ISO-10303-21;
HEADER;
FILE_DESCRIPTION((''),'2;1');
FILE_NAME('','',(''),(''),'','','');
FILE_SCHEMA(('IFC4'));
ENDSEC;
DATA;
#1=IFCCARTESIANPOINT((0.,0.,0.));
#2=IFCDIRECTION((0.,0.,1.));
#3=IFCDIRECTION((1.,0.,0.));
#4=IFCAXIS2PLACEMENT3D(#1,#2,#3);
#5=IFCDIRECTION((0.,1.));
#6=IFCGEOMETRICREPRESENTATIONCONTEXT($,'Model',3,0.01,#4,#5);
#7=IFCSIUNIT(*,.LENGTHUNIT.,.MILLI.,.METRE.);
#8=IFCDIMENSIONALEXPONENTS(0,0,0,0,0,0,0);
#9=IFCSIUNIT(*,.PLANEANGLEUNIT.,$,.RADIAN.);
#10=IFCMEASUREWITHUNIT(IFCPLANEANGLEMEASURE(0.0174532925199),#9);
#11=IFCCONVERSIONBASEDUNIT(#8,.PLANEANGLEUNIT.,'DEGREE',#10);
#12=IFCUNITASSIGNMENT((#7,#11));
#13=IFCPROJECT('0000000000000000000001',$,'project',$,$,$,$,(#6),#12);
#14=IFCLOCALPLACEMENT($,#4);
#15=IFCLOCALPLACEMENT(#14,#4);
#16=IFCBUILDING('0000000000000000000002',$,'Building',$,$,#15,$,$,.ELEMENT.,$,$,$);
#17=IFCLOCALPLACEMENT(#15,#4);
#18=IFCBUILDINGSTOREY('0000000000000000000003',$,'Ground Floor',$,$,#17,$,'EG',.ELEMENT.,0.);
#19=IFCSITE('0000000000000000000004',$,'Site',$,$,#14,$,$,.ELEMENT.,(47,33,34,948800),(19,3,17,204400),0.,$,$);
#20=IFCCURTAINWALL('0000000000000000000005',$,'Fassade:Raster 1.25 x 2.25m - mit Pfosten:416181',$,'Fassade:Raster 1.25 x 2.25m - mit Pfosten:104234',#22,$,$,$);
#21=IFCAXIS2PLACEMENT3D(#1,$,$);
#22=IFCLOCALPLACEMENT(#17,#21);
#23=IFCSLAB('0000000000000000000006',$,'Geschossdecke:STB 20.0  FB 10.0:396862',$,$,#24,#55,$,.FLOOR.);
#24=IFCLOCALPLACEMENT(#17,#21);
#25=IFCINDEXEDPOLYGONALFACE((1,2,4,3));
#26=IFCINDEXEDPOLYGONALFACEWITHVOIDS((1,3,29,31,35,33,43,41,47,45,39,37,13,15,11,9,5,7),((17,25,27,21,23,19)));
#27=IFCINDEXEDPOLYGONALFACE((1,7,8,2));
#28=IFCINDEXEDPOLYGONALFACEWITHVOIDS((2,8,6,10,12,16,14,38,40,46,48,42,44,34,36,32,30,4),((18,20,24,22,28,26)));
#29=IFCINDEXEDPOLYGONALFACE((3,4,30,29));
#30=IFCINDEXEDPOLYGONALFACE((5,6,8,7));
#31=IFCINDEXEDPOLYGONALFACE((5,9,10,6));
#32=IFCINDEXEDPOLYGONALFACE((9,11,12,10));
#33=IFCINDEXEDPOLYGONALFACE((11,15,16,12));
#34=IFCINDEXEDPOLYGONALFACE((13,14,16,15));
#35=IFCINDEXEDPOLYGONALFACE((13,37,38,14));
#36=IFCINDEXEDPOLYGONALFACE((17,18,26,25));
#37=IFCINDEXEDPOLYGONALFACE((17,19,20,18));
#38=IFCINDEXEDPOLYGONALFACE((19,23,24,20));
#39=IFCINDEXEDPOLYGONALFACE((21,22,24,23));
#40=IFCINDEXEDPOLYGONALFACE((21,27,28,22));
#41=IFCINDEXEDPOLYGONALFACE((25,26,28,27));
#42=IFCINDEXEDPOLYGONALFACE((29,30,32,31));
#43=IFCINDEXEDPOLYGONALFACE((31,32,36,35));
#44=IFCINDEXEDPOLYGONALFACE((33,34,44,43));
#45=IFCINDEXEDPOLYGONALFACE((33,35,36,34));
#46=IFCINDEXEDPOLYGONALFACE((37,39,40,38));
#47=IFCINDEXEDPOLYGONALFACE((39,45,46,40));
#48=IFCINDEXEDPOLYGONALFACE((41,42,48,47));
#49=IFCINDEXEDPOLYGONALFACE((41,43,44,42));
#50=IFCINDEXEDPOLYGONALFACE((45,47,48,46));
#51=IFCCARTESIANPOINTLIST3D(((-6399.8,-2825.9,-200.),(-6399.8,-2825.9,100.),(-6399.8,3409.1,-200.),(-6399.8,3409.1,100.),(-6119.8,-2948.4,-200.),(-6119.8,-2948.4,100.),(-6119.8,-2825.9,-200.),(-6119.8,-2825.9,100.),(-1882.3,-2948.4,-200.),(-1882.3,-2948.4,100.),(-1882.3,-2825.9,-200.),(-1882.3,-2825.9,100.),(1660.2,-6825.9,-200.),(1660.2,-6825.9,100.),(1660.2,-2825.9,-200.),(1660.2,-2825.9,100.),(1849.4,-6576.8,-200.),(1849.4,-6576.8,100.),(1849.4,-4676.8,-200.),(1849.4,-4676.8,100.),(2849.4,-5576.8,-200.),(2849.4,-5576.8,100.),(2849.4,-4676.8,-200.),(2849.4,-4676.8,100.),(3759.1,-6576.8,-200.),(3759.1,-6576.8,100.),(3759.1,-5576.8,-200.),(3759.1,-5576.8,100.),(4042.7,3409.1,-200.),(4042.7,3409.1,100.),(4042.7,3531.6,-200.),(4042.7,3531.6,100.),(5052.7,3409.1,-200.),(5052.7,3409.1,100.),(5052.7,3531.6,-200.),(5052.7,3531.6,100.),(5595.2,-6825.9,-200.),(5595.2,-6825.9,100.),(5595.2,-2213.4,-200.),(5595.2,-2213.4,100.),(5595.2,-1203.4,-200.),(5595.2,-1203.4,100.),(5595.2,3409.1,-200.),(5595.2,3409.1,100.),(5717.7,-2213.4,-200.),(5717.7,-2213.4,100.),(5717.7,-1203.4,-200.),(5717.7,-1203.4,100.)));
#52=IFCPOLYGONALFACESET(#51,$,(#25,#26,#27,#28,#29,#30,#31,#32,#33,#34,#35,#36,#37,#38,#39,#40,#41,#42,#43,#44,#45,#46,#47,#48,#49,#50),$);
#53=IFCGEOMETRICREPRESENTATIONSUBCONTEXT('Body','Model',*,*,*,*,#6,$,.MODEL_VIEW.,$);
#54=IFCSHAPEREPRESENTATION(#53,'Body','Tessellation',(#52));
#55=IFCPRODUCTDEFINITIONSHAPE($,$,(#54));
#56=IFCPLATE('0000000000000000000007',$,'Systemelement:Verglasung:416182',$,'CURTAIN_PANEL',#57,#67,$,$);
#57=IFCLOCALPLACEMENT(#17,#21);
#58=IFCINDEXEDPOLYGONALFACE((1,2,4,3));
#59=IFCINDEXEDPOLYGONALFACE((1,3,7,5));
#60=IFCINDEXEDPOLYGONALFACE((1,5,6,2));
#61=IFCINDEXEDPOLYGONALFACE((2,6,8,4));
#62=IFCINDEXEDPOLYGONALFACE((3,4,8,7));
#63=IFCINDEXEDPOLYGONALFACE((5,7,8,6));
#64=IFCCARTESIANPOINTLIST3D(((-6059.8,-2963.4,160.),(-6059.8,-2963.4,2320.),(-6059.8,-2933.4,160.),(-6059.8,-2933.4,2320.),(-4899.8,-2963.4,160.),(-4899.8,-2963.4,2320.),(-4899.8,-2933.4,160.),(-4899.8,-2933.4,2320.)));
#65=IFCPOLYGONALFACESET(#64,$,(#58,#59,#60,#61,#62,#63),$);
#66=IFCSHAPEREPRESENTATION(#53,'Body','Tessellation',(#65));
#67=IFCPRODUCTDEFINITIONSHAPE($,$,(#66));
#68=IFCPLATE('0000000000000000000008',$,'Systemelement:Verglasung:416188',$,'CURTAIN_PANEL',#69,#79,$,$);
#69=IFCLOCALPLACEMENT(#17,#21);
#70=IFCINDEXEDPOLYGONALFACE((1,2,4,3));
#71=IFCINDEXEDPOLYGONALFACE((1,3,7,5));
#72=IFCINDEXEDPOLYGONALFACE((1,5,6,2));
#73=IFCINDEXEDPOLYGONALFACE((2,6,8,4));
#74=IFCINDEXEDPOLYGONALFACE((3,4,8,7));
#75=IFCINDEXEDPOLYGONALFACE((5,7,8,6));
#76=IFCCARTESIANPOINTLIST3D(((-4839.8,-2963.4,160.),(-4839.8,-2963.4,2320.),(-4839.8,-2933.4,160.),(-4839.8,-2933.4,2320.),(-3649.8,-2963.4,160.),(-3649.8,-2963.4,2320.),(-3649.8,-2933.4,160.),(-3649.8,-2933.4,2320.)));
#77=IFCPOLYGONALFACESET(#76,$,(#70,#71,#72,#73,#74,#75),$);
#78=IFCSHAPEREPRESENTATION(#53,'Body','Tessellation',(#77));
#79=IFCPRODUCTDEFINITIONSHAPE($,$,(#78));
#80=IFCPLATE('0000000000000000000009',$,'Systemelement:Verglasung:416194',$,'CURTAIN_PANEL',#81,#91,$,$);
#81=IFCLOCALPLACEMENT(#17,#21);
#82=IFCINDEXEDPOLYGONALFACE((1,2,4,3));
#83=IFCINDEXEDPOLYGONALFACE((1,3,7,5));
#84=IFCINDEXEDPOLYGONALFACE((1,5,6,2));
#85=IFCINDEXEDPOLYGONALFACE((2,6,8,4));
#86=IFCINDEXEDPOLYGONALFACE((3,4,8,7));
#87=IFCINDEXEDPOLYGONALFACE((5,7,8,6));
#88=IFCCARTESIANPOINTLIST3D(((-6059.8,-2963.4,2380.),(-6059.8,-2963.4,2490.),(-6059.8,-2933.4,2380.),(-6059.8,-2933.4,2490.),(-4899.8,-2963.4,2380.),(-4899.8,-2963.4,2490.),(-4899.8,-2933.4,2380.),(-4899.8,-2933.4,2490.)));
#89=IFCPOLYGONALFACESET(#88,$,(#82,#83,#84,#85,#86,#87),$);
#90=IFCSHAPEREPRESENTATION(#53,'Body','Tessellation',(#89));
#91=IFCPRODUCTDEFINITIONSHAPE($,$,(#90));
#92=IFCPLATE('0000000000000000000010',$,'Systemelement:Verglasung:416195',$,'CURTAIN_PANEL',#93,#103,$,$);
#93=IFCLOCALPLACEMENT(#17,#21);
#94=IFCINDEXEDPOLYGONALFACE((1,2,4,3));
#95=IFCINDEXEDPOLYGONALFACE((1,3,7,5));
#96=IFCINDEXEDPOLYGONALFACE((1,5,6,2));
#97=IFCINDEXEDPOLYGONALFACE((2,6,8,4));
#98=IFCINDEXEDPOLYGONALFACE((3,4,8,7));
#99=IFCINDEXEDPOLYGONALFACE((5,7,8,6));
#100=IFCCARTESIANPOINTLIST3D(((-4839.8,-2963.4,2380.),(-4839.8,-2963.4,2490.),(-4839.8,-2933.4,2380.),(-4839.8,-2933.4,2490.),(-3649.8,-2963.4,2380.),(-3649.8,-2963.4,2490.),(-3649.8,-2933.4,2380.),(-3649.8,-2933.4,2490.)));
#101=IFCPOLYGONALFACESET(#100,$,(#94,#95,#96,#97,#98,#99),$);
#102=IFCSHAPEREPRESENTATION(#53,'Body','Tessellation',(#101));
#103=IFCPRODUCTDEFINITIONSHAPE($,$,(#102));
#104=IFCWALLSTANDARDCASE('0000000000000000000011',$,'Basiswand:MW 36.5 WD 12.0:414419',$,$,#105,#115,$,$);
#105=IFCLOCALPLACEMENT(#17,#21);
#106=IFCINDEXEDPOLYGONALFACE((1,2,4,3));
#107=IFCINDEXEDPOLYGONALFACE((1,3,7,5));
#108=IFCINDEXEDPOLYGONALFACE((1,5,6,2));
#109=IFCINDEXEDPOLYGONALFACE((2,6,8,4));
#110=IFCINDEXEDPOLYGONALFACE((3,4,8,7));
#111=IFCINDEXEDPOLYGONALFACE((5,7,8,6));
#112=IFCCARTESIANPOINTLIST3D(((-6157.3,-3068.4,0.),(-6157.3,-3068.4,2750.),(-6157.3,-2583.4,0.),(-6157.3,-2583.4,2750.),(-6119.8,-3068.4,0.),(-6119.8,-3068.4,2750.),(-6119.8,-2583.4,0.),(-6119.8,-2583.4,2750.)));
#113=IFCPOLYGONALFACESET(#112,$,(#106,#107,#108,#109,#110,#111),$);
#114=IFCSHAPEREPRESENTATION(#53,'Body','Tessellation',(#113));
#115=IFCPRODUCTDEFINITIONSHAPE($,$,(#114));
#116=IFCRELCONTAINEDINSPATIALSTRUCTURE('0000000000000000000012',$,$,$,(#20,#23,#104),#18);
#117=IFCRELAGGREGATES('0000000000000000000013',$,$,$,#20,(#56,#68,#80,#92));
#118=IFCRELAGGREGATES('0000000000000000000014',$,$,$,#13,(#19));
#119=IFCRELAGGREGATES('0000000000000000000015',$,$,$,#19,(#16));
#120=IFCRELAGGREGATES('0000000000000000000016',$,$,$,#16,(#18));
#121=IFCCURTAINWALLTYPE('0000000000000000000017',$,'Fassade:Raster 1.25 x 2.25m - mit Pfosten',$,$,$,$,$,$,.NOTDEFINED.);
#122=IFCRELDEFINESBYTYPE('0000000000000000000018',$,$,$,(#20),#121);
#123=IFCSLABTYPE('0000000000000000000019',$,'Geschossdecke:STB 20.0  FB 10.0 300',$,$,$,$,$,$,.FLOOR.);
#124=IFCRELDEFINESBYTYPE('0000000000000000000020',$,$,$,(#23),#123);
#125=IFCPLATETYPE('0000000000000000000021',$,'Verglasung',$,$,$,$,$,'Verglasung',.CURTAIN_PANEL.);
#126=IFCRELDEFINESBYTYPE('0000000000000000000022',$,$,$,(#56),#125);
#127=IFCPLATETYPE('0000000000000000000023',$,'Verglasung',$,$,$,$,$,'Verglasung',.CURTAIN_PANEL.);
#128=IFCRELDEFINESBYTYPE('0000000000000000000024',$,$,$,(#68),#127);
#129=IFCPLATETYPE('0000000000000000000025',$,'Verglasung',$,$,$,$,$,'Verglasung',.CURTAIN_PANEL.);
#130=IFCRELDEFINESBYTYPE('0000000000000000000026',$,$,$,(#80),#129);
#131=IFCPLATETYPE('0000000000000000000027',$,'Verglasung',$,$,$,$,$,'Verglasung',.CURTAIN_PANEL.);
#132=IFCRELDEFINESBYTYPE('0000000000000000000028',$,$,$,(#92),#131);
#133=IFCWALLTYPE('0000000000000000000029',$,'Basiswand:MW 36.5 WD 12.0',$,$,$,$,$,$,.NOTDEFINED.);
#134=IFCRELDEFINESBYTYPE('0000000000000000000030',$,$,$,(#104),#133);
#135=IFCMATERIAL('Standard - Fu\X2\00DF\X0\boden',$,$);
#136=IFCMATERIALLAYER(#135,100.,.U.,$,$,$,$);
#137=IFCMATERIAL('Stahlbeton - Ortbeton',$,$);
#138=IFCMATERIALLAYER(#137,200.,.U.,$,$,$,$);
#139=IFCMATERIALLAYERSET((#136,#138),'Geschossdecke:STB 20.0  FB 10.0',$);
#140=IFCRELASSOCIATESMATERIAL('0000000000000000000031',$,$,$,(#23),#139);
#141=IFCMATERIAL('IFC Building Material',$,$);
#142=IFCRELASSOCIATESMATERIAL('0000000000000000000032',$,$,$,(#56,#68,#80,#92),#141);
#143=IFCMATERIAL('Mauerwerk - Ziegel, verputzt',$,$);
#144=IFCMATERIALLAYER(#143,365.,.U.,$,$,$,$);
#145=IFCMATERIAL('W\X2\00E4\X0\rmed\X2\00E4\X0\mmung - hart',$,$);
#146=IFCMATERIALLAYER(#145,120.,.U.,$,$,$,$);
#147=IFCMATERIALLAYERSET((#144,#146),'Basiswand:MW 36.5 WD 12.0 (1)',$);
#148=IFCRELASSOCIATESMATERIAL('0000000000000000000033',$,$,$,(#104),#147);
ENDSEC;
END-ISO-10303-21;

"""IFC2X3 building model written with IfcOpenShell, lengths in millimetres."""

from ifc_helpers import new_model, entity, si_unit, converted_unit, direction, frame, origin_with_axes, origin_2d_with_axis, place, context, subcontext, project, spatial, polyline, rectangle, outline, extrude, material, layer, layer_set, layer_usage, type_object, element, aggregate, save


model = new_model("IFC2X3")

# Units and contexts
model_context = context("Model", 3, precision=0.01, world=origin_with_axes(), true_north=direction((0.0, 1.0)))
body_context = subcontext(model_context, "Body", "Model", "MODEL_VIEW")
ifc_project = project(units=[si_unit("LENGTHUNIT", "METRE", prefix="MILLI"), converted_unit("PLANEANGLEUNIT", "DEGREE", entity("IfcPlaneAngleMeasure", 0.0174532925199), si_unit("PLANEANGLEUNIT", "RADIAN"), dimensions=[0, 0, 0, 0, 0, 0, 0])], contexts=[model_context])

# Site, building, storey
site_placement = place(None, origin_with_axes())
site = spatial("IfcSite", under=ifc_project, at=site_placement, Name="Site", CompositionType="ELEMENT", RefLatitude=(47, 33, 34, 948800), RefLongitude=(19, 3, 17, 204400), RefElevation=0.0)
building_placement = place(site_placement, origin_with_axes())
building = spatial("IfcBuilding", under=site, at=building_placement, Name="Building", CompositionType="ELEMENT")
storey_placement = place(building_placement, origin_with_axes())
storey = spatial("IfcBuildingStorey", under=building, at=storey_placement, Name="Ground Floor", LongName="EG", CompositionType="ELEMENT", Elevation=0.0)

# Curtain wall
curtain_wall_type = type_object("IfcCurtainWallType", Name="Fassade:Raster 1.25 x 2.25m - mit Pfosten", PredefinedType="NOTDEFINED")
curtain_wall_placement = place(storey_placement, origin_with_axes())
curtain_wall = element("IfcCurtainWall", 1, at=curtain_wall_placement, inside=storey, type_object=curtain_wall_type, Name="Fassade:Raster 1.25 x 2.25m - mit Pfosten:416181", ObjectType="Fassade:Raster 1.25 x 2.25m - mit Pfosten:104234")

# Slab, opening
ifc_material_1 = material(Name="Standard - Fußboden")
ifc_layer_1 = layer(ifc_material_1, 100.0, ventilated="UNKNOWN")
ifc_material_2 = material(Name="Stahlbeton - Ortbeton")
ifc_layer_2 = layer(ifc_material_2, 200.0, ventilated="UNKNOWN")
ifc_layer_set_1 = layer_set([ifc_layer_1, ifc_layer_2], Name="Geschossdecke:STB 20.0  FB 10.0")
ifc_layer_usage_1 = layer_usage(ifc_layer_set_1, "AXIS3", "NEGATIVE", 300.0)
slab_type = type_object("IfcSlabType", Name="Geschossdecke:STB 20.0  FB 10.0 300", PredefinedType="FLOOR")
slab_placement = place(storey_placement, frame((-6399.8, 3409.1, 100.0), z_axis=(0.0, 0.0, 1.0), x_axis=(1.0, 0.0, 0.0)))
slab = element("IfcSlab", 2, at=slab_placement, inside=storey, type_object=slab_type, material=ifc_layer_usage_1, Name="Geschossdecke:STB 20.0  FB 10.0:396862", PredefinedType="FLOOR", context=body_context, shape_type="SweptSolid", body=[
    extrude(outline(polyline([(0.0, 0.0), (0.0, -6235.0), (280.0, -6235.0), (280.0, -6357.5), (4517.5, -6357.5), (4517.5, -6235.0), (8060.0, -6235.0), (8060.0, -10235.0), (11995.0, -10235.0), (11995.0, -5622.5), (12117.5, -5622.5), (12117.5, -4612.5), (11995.0, -4612.5), (11995.0, 0.0), (11452.5, 0.0), (11452.5, 122.5), (10442.5, 122.5), (10442.5, 0.0), (0.0, 0.0)])), frame((0.0, 0.0, -300.0), z_axis=(0.0, 0.0, 1.0), x_axis=(1.0, 0.0, 0.0)), (0.0, 0.0, 1.0), 300.0),
])
opening_placement = place(slab_placement, frame((8249.2, -8085.8, 0.0), z_axis=(0.0, 0.0, 1.0), x_axis=(0.0, -1.0, 0.0)))
element("IfcOpeningElement", 3, at=opening_placement, cuts=slab, context=body_context, shape_type="SweptSolid", body=[
    extrude(outline(polyline([(0.0, 0.0), (1900.0, 0.0), (1900.0, 1909.7), (900.0, 1909.7), (900.0, 1000.0), (0.0, 1000.0), (0.0, 0.0)])), frame((0.0, 0.0, -300.0), z_axis=(0.0, 0.0, 1.0), x_axis=(1.0, 0.0, 0.0)), (0.0, 0.0, 1.0), 300.0),
])

# Plates
ifc_material_3 = material(Name="IFC Building Material")
plate_type_1 = type_object("IfcPlateType", Name="Verglasung", ElementType="Verglasung", PredefinedType="CURTAIN_PANEL")
plate_1_placement = place(curtain_wall_placement, frame((-5479.8, -2948.4, 160.0), z_axis=(0.0, 0.0, 1.0), x_axis=(1.0, 0.0, 0.0)))
plate_1 = element("IfcPlate", 4, at=plate_1_placement, type_object=plate_type_1, material=ifc_material_3, Name="Systemelement:Verglasung:416182", ObjectType="CURTAIN_PANEL", context=body_context, shape_type="SweptSolid", body=[
    extrude(rectangle(XDim=30.0, YDim=1160.0, at=origin_2d_with_axis()), frame((0.0, 0.0, 0.0), z_axis=(0.0, 0.0, 1.0), x_axis=(0.0, 1.0, 0.0)), (0.0, 0.0, 1.0), 2160.0),
])
plate_type_2 = type_object("IfcPlateType", Name="Verglasung", ElementType="Verglasung", PredefinedType="CURTAIN_PANEL")
plate_2_placement = place(curtain_wall_placement, frame((-4244.8, -2948.4, 160.0), z_axis=(0.0, 0.0, 1.0), x_axis=(1.0, 0.0, 0.0)))
plate_2 = element("IfcPlate", 5, at=plate_2_placement, type_object=plate_type_2, material=ifc_material_3, Name="Systemelement:Verglasung:416188", ObjectType="CURTAIN_PANEL", context=body_context, shape_type="SweptSolid", body=[
    extrude(rectangle(XDim=30.0, YDim=1190.0, at=origin_2d_with_axis()), frame((0.0, 0.0, 0.0), z_axis=(0.0, 0.0, 1.0), x_axis=(0.0, 1.0, 0.0)), (0.0, 0.0, 1.0), 2160.0),
])
plate_type_3 = type_object("IfcPlateType", Name="Verglasung", ElementType="Verglasung", PredefinedType="CURTAIN_PANEL")
plate_3_placement = place(curtain_wall_placement, frame((-5479.8, -2948.4, 2380.0), z_axis=(0.0, 0.0, 1.0), x_axis=(1.0, 0.0, 0.0)))
plate_3 = element("IfcPlate", 6, at=plate_3_placement, type_object=plate_type_3, material=ifc_material_3, Name="Systemelement:Verglasung:416194", ObjectType="CURTAIN_PANEL", context=body_context, shape_type="SweptSolid", body=[
    extrude(rectangle(XDim=30.0, YDim=1160.0, at=origin_2d_with_axis()), frame((0.0, 0.0, 0.0), z_axis=(0.0, 0.0, 1.0), x_axis=(0.0, 1.0, 0.0)), (0.0, 0.0, 1.0), 110.0),
])
plate_type_4 = type_object("IfcPlateType", Name="Verglasung", ElementType="Verglasung", PredefinedType="CURTAIN_PANEL")
plate_4_placement = place(curtain_wall_placement, frame((-4244.8, -2948.4, 2380.0), z_axis=(0.0, 0.0, 1.0), x_axis=(1.0, 0.0, 0.0)))
plate_4 = element("IfcPlate", 7, at=plate_4_placement, type_object=plate_type_4, material=ifc_material_3, Name="Systemelement:Verglasung:416195", ObjectType="CURTAIN_PANEL", context=body_context, shape_type="SweptSolid", body=[
    extrude(rectangle(XDim=30.0, YDim=1190.0, at=origin_2d_with_axis()), frame((0.0, 0.0, 0.0), z_axis=(0.0, 0.0, 1.0), x_axis=(0.0, 1.0, 0.0)), (0.0, 0.0, 1.0), 110.0),
])
aggregate(curtain_wall, [plate_1, plate_2, plate_3, plate_4])

# Wall
ifc_material_4 = material(Name="Mauerwerk - Ziegel, verputzt")
ifc_layer_3 = layer(ifc_material_4, 365.0, ventilated="UNKNOWN")
ifc_material_5 = material(Name="Wärmedämmung - hart")
ifc_layer_4 = layer(ifc_material_5, 120.0, ventilated="UNKNOWN")
ifc_layer_set_2 = layer_set([ifc_layer_3, ifc_layer_4], Name="Basiswand:MW 36.5 WD 12.0 (1)")
ifc_layer_usage_2 = layer_usage(ifc_layer_set_2, "AXIS2", "POSITIVE", -242.5)
wall_type = type_object("IfcWallType", Name="Basiswand:MW 36.5 WD 12.0", PredefinedType="NOTDEFINED")
wall_placement = place(storey_placement, frame((-6119.8, -2825.9, 0.0), z_axis=(0.0, 0.0, 1.0), x_axis=(-1.0, 0.0, 0.0)))
element("IfcWallStandardCase", 8, at=wall_placement, inside=storey, type_object=wall_type, material=ifc_layer_usage_2, Name="Basiswand:MW 36.5 WD 12.0:414419", context=body_context, shape_type="SweptSolid", body=[
    extrude(outline(polyline([(0.0, -242.5), (37.5, -242.5), (37.5, 242.5), (0.0, 242.5), (0.0, -242.5)])), origin_with_axes(), (0.0, 0.0, 1.0), 2750.0),
])

save(model, "model.ifc")
